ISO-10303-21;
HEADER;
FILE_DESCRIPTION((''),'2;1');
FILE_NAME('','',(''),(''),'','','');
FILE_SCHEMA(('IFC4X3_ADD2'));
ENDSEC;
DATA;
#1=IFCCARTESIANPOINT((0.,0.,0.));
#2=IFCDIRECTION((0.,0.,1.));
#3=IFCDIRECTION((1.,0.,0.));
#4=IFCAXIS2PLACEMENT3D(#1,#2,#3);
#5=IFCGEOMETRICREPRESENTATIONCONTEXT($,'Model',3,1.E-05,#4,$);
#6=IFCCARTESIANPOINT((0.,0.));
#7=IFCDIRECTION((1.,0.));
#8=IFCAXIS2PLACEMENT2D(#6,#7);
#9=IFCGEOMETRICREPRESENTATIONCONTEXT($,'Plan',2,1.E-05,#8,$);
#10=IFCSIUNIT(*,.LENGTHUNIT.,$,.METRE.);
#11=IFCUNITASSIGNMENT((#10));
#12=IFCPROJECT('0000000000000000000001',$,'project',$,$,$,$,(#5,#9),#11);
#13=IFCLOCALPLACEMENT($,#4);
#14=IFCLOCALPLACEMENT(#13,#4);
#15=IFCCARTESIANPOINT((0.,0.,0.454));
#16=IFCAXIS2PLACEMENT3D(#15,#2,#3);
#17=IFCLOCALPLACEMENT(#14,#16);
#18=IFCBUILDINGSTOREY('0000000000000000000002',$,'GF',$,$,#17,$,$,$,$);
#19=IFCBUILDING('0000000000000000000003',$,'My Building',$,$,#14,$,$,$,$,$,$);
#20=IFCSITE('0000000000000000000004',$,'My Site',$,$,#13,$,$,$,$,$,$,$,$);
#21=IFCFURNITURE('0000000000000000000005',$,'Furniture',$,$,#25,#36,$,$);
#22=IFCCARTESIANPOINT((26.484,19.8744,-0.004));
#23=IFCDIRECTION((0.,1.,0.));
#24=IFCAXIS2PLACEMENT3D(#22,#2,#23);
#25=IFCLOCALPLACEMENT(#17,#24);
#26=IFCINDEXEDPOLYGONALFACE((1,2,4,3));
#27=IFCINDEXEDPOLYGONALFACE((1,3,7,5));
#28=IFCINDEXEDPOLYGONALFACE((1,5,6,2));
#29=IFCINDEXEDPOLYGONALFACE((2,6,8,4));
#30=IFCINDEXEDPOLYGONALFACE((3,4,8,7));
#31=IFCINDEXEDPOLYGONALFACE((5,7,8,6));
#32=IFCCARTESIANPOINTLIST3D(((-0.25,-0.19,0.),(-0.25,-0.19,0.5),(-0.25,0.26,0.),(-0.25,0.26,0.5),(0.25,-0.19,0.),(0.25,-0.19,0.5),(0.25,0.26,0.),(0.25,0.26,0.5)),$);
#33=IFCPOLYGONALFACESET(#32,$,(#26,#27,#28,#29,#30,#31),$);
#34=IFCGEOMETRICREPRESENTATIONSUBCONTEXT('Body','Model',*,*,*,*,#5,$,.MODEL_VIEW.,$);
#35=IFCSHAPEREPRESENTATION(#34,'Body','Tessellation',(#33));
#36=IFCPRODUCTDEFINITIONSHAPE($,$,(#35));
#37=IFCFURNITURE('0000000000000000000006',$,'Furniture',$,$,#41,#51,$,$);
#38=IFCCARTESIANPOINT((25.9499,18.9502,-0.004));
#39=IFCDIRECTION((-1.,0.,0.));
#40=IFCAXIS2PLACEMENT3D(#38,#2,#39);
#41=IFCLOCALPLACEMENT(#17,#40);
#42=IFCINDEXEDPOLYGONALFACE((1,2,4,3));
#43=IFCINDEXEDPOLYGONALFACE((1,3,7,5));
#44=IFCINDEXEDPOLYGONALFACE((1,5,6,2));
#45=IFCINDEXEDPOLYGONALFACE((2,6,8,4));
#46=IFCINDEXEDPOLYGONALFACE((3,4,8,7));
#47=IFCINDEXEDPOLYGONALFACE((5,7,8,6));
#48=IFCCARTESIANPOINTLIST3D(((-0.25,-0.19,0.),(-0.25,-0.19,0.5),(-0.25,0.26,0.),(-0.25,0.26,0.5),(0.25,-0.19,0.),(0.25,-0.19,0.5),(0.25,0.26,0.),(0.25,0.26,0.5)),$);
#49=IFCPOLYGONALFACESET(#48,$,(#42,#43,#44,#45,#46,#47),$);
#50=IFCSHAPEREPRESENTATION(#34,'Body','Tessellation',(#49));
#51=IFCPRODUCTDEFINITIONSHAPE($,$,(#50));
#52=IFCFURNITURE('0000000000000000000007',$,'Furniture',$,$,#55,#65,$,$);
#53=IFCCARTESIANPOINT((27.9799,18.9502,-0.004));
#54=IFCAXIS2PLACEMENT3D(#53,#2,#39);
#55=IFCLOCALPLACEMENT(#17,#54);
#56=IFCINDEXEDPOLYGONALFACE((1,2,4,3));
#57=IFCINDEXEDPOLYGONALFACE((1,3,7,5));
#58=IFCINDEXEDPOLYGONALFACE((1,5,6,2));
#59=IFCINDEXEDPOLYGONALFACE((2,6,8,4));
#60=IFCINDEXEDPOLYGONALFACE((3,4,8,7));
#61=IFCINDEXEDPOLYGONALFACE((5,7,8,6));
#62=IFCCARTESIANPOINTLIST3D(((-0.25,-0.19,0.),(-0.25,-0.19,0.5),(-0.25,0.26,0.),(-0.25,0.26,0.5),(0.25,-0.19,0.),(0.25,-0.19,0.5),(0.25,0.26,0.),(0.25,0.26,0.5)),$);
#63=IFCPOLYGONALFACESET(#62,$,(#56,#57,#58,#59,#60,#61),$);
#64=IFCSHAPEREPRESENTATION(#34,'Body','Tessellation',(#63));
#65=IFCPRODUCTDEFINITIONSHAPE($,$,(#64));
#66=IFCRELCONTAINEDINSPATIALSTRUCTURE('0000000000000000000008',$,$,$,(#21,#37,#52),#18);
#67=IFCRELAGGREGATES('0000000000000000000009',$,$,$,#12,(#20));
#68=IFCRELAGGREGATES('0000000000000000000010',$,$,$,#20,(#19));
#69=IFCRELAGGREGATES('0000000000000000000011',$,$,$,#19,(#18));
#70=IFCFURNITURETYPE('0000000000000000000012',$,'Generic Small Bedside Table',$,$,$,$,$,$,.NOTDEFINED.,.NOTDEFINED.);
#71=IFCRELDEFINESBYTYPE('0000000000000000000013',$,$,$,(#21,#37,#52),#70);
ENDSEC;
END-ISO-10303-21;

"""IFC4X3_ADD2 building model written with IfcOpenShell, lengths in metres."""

from ifc_helpers import new_model, entity, si_unit, frame, origin_with_axes, origin_2d_with_axis, place, context, subcontext, project, spatial, line, indexed_curve, outline, extrude, shape, source, transform, mapped, type_object, type_shapes, element, save


model = new_model("IFC4X3_ADD2")

# Units and contexts
model_context = context("Model", 3, precision=1e-05, world=origin_with_axes())
plan_context = context("Plan", 2, precision=1e-05, world=origin_2d_with_axis())
body_context_1 = subcontext(model_context, "Body", "Model", "MODEL_VIEW")
body_context_2 = subcontext(plan_context, "Body", "Plan", "PLAN_VIEW")
ifc_project = project(units=[si_unit("LENGTHUNIT", "METRE")], contexts=[model_context, plan_context])

# Site, building, storey
site_placement = place(None, origin_with_axes())
site = spatial("IfcSite", under=ifc_project, at=site_placement, Name="My Site")
building_placement = place(site_placement, origin_with_axes())
building = spatial("IfcBuilding", under=site, at=building_placement, Name="My Building")
storey_placement = place(building_placement, frame((0.0, 0.0, 0.454), z_axis=(0.0, 0.0, 1.0), x_axis=(1.0, 0.0, 0.0)))
storey = spatial("IfcBuildingStorey", under=building, at=storey_placement, Name="GF")

# Furniture
furniture_type_1 = type_object("IfcFurnitureType", Name="Generic Small Bedside Table", AssemblyPlace="NOTDEFINED", PredefinedType="NOTDEFINED")
shared_shape_1 = source(origin_with_axes(), body_context_1, "Body", "SweptSolid", [
    extrude(outline(indexed_curve([(0.5, 0.45), (0.5, 0.0), (0.0, 0.0), (0.0, 0.45)], segments=[line(4, 1), line(1, 2), line(2, 3), line(3, 4)], self_intersect=False)), frame((-0.25, -0.19, 0.0), z_axis=(0.0, 0.0, 1.0), x_axis=(1.0, 0.0, 0.0)), (0.0, 0.0, 1.0), 0.5),
])
shared_shape_2 = source(origin_with_axes(), body_context_2, "Body", "Annotation2D", [
    entity("IfcGeometricCurveSet", [entity("IfcIndexedPolyCurve", entity("IfcCartesianPointList2D", [[-0.25, -0.19], [0.25, -0.19], [0.25, 0.26], [-0.25, 0.26]]), [entity("IfcLineIndex", [1, 2]), entity("IfcLineIndex", [2, 3]), entity("IfcLineIndex", [3, 4]), entity("IfcLineIndex", [4, 1])])]),
])
type_shapes(furniture_type_1, [shared_shape_1, shared_shape_2])
for number, where, z_axis, x_axis, name in (
    (1, (26.484, 19.8744, -0.004), (0.0, 0.0, 1.0), (0.0, 1.0, 0.0), "Furniture"),
    (2, (25.9499, 18.9502, -0.004), (0.0, 0.0, 1.0), (-1.0, 0.0, 0.0), "Furniture"),
    (3, (27.9799, 18.9502, -0.004), (0.0, 0.0, 1.0), (-1.0, 0.0, 0.0), "Furniture"),
):
    element("IfcFurniture", number, at=place(storey_placement, frame(where, z_axis=z_axis, x_axis=x_axis)), inside=storey, type_object=furniture_type_1, Name=name, shapes=[
        shape(body_context_1, "Body", "MappedRepresentation", [mapped(shared_shape_1, transform((0.0, 0.0, 0.0), x_axis=(1.0, 0.0, 0.0), y_axis=(0.0, 1.0, 0.0), z_axis=(0.0, 0.0, 1.0), scale=1.0))]),
        shape(body_context_2, "Body", "MappedRepresentation", [mapped(shared_shape_2, transform((0.0, 0.0, 0.0), x_axis=(1.0, 0.0, 0.0), y_axis=(0.0, 1.0, 0.0), z_axis=(0.0, 0.0, 1.0), scale=1.0))]),
    ])

save(model, "model.ifc")
